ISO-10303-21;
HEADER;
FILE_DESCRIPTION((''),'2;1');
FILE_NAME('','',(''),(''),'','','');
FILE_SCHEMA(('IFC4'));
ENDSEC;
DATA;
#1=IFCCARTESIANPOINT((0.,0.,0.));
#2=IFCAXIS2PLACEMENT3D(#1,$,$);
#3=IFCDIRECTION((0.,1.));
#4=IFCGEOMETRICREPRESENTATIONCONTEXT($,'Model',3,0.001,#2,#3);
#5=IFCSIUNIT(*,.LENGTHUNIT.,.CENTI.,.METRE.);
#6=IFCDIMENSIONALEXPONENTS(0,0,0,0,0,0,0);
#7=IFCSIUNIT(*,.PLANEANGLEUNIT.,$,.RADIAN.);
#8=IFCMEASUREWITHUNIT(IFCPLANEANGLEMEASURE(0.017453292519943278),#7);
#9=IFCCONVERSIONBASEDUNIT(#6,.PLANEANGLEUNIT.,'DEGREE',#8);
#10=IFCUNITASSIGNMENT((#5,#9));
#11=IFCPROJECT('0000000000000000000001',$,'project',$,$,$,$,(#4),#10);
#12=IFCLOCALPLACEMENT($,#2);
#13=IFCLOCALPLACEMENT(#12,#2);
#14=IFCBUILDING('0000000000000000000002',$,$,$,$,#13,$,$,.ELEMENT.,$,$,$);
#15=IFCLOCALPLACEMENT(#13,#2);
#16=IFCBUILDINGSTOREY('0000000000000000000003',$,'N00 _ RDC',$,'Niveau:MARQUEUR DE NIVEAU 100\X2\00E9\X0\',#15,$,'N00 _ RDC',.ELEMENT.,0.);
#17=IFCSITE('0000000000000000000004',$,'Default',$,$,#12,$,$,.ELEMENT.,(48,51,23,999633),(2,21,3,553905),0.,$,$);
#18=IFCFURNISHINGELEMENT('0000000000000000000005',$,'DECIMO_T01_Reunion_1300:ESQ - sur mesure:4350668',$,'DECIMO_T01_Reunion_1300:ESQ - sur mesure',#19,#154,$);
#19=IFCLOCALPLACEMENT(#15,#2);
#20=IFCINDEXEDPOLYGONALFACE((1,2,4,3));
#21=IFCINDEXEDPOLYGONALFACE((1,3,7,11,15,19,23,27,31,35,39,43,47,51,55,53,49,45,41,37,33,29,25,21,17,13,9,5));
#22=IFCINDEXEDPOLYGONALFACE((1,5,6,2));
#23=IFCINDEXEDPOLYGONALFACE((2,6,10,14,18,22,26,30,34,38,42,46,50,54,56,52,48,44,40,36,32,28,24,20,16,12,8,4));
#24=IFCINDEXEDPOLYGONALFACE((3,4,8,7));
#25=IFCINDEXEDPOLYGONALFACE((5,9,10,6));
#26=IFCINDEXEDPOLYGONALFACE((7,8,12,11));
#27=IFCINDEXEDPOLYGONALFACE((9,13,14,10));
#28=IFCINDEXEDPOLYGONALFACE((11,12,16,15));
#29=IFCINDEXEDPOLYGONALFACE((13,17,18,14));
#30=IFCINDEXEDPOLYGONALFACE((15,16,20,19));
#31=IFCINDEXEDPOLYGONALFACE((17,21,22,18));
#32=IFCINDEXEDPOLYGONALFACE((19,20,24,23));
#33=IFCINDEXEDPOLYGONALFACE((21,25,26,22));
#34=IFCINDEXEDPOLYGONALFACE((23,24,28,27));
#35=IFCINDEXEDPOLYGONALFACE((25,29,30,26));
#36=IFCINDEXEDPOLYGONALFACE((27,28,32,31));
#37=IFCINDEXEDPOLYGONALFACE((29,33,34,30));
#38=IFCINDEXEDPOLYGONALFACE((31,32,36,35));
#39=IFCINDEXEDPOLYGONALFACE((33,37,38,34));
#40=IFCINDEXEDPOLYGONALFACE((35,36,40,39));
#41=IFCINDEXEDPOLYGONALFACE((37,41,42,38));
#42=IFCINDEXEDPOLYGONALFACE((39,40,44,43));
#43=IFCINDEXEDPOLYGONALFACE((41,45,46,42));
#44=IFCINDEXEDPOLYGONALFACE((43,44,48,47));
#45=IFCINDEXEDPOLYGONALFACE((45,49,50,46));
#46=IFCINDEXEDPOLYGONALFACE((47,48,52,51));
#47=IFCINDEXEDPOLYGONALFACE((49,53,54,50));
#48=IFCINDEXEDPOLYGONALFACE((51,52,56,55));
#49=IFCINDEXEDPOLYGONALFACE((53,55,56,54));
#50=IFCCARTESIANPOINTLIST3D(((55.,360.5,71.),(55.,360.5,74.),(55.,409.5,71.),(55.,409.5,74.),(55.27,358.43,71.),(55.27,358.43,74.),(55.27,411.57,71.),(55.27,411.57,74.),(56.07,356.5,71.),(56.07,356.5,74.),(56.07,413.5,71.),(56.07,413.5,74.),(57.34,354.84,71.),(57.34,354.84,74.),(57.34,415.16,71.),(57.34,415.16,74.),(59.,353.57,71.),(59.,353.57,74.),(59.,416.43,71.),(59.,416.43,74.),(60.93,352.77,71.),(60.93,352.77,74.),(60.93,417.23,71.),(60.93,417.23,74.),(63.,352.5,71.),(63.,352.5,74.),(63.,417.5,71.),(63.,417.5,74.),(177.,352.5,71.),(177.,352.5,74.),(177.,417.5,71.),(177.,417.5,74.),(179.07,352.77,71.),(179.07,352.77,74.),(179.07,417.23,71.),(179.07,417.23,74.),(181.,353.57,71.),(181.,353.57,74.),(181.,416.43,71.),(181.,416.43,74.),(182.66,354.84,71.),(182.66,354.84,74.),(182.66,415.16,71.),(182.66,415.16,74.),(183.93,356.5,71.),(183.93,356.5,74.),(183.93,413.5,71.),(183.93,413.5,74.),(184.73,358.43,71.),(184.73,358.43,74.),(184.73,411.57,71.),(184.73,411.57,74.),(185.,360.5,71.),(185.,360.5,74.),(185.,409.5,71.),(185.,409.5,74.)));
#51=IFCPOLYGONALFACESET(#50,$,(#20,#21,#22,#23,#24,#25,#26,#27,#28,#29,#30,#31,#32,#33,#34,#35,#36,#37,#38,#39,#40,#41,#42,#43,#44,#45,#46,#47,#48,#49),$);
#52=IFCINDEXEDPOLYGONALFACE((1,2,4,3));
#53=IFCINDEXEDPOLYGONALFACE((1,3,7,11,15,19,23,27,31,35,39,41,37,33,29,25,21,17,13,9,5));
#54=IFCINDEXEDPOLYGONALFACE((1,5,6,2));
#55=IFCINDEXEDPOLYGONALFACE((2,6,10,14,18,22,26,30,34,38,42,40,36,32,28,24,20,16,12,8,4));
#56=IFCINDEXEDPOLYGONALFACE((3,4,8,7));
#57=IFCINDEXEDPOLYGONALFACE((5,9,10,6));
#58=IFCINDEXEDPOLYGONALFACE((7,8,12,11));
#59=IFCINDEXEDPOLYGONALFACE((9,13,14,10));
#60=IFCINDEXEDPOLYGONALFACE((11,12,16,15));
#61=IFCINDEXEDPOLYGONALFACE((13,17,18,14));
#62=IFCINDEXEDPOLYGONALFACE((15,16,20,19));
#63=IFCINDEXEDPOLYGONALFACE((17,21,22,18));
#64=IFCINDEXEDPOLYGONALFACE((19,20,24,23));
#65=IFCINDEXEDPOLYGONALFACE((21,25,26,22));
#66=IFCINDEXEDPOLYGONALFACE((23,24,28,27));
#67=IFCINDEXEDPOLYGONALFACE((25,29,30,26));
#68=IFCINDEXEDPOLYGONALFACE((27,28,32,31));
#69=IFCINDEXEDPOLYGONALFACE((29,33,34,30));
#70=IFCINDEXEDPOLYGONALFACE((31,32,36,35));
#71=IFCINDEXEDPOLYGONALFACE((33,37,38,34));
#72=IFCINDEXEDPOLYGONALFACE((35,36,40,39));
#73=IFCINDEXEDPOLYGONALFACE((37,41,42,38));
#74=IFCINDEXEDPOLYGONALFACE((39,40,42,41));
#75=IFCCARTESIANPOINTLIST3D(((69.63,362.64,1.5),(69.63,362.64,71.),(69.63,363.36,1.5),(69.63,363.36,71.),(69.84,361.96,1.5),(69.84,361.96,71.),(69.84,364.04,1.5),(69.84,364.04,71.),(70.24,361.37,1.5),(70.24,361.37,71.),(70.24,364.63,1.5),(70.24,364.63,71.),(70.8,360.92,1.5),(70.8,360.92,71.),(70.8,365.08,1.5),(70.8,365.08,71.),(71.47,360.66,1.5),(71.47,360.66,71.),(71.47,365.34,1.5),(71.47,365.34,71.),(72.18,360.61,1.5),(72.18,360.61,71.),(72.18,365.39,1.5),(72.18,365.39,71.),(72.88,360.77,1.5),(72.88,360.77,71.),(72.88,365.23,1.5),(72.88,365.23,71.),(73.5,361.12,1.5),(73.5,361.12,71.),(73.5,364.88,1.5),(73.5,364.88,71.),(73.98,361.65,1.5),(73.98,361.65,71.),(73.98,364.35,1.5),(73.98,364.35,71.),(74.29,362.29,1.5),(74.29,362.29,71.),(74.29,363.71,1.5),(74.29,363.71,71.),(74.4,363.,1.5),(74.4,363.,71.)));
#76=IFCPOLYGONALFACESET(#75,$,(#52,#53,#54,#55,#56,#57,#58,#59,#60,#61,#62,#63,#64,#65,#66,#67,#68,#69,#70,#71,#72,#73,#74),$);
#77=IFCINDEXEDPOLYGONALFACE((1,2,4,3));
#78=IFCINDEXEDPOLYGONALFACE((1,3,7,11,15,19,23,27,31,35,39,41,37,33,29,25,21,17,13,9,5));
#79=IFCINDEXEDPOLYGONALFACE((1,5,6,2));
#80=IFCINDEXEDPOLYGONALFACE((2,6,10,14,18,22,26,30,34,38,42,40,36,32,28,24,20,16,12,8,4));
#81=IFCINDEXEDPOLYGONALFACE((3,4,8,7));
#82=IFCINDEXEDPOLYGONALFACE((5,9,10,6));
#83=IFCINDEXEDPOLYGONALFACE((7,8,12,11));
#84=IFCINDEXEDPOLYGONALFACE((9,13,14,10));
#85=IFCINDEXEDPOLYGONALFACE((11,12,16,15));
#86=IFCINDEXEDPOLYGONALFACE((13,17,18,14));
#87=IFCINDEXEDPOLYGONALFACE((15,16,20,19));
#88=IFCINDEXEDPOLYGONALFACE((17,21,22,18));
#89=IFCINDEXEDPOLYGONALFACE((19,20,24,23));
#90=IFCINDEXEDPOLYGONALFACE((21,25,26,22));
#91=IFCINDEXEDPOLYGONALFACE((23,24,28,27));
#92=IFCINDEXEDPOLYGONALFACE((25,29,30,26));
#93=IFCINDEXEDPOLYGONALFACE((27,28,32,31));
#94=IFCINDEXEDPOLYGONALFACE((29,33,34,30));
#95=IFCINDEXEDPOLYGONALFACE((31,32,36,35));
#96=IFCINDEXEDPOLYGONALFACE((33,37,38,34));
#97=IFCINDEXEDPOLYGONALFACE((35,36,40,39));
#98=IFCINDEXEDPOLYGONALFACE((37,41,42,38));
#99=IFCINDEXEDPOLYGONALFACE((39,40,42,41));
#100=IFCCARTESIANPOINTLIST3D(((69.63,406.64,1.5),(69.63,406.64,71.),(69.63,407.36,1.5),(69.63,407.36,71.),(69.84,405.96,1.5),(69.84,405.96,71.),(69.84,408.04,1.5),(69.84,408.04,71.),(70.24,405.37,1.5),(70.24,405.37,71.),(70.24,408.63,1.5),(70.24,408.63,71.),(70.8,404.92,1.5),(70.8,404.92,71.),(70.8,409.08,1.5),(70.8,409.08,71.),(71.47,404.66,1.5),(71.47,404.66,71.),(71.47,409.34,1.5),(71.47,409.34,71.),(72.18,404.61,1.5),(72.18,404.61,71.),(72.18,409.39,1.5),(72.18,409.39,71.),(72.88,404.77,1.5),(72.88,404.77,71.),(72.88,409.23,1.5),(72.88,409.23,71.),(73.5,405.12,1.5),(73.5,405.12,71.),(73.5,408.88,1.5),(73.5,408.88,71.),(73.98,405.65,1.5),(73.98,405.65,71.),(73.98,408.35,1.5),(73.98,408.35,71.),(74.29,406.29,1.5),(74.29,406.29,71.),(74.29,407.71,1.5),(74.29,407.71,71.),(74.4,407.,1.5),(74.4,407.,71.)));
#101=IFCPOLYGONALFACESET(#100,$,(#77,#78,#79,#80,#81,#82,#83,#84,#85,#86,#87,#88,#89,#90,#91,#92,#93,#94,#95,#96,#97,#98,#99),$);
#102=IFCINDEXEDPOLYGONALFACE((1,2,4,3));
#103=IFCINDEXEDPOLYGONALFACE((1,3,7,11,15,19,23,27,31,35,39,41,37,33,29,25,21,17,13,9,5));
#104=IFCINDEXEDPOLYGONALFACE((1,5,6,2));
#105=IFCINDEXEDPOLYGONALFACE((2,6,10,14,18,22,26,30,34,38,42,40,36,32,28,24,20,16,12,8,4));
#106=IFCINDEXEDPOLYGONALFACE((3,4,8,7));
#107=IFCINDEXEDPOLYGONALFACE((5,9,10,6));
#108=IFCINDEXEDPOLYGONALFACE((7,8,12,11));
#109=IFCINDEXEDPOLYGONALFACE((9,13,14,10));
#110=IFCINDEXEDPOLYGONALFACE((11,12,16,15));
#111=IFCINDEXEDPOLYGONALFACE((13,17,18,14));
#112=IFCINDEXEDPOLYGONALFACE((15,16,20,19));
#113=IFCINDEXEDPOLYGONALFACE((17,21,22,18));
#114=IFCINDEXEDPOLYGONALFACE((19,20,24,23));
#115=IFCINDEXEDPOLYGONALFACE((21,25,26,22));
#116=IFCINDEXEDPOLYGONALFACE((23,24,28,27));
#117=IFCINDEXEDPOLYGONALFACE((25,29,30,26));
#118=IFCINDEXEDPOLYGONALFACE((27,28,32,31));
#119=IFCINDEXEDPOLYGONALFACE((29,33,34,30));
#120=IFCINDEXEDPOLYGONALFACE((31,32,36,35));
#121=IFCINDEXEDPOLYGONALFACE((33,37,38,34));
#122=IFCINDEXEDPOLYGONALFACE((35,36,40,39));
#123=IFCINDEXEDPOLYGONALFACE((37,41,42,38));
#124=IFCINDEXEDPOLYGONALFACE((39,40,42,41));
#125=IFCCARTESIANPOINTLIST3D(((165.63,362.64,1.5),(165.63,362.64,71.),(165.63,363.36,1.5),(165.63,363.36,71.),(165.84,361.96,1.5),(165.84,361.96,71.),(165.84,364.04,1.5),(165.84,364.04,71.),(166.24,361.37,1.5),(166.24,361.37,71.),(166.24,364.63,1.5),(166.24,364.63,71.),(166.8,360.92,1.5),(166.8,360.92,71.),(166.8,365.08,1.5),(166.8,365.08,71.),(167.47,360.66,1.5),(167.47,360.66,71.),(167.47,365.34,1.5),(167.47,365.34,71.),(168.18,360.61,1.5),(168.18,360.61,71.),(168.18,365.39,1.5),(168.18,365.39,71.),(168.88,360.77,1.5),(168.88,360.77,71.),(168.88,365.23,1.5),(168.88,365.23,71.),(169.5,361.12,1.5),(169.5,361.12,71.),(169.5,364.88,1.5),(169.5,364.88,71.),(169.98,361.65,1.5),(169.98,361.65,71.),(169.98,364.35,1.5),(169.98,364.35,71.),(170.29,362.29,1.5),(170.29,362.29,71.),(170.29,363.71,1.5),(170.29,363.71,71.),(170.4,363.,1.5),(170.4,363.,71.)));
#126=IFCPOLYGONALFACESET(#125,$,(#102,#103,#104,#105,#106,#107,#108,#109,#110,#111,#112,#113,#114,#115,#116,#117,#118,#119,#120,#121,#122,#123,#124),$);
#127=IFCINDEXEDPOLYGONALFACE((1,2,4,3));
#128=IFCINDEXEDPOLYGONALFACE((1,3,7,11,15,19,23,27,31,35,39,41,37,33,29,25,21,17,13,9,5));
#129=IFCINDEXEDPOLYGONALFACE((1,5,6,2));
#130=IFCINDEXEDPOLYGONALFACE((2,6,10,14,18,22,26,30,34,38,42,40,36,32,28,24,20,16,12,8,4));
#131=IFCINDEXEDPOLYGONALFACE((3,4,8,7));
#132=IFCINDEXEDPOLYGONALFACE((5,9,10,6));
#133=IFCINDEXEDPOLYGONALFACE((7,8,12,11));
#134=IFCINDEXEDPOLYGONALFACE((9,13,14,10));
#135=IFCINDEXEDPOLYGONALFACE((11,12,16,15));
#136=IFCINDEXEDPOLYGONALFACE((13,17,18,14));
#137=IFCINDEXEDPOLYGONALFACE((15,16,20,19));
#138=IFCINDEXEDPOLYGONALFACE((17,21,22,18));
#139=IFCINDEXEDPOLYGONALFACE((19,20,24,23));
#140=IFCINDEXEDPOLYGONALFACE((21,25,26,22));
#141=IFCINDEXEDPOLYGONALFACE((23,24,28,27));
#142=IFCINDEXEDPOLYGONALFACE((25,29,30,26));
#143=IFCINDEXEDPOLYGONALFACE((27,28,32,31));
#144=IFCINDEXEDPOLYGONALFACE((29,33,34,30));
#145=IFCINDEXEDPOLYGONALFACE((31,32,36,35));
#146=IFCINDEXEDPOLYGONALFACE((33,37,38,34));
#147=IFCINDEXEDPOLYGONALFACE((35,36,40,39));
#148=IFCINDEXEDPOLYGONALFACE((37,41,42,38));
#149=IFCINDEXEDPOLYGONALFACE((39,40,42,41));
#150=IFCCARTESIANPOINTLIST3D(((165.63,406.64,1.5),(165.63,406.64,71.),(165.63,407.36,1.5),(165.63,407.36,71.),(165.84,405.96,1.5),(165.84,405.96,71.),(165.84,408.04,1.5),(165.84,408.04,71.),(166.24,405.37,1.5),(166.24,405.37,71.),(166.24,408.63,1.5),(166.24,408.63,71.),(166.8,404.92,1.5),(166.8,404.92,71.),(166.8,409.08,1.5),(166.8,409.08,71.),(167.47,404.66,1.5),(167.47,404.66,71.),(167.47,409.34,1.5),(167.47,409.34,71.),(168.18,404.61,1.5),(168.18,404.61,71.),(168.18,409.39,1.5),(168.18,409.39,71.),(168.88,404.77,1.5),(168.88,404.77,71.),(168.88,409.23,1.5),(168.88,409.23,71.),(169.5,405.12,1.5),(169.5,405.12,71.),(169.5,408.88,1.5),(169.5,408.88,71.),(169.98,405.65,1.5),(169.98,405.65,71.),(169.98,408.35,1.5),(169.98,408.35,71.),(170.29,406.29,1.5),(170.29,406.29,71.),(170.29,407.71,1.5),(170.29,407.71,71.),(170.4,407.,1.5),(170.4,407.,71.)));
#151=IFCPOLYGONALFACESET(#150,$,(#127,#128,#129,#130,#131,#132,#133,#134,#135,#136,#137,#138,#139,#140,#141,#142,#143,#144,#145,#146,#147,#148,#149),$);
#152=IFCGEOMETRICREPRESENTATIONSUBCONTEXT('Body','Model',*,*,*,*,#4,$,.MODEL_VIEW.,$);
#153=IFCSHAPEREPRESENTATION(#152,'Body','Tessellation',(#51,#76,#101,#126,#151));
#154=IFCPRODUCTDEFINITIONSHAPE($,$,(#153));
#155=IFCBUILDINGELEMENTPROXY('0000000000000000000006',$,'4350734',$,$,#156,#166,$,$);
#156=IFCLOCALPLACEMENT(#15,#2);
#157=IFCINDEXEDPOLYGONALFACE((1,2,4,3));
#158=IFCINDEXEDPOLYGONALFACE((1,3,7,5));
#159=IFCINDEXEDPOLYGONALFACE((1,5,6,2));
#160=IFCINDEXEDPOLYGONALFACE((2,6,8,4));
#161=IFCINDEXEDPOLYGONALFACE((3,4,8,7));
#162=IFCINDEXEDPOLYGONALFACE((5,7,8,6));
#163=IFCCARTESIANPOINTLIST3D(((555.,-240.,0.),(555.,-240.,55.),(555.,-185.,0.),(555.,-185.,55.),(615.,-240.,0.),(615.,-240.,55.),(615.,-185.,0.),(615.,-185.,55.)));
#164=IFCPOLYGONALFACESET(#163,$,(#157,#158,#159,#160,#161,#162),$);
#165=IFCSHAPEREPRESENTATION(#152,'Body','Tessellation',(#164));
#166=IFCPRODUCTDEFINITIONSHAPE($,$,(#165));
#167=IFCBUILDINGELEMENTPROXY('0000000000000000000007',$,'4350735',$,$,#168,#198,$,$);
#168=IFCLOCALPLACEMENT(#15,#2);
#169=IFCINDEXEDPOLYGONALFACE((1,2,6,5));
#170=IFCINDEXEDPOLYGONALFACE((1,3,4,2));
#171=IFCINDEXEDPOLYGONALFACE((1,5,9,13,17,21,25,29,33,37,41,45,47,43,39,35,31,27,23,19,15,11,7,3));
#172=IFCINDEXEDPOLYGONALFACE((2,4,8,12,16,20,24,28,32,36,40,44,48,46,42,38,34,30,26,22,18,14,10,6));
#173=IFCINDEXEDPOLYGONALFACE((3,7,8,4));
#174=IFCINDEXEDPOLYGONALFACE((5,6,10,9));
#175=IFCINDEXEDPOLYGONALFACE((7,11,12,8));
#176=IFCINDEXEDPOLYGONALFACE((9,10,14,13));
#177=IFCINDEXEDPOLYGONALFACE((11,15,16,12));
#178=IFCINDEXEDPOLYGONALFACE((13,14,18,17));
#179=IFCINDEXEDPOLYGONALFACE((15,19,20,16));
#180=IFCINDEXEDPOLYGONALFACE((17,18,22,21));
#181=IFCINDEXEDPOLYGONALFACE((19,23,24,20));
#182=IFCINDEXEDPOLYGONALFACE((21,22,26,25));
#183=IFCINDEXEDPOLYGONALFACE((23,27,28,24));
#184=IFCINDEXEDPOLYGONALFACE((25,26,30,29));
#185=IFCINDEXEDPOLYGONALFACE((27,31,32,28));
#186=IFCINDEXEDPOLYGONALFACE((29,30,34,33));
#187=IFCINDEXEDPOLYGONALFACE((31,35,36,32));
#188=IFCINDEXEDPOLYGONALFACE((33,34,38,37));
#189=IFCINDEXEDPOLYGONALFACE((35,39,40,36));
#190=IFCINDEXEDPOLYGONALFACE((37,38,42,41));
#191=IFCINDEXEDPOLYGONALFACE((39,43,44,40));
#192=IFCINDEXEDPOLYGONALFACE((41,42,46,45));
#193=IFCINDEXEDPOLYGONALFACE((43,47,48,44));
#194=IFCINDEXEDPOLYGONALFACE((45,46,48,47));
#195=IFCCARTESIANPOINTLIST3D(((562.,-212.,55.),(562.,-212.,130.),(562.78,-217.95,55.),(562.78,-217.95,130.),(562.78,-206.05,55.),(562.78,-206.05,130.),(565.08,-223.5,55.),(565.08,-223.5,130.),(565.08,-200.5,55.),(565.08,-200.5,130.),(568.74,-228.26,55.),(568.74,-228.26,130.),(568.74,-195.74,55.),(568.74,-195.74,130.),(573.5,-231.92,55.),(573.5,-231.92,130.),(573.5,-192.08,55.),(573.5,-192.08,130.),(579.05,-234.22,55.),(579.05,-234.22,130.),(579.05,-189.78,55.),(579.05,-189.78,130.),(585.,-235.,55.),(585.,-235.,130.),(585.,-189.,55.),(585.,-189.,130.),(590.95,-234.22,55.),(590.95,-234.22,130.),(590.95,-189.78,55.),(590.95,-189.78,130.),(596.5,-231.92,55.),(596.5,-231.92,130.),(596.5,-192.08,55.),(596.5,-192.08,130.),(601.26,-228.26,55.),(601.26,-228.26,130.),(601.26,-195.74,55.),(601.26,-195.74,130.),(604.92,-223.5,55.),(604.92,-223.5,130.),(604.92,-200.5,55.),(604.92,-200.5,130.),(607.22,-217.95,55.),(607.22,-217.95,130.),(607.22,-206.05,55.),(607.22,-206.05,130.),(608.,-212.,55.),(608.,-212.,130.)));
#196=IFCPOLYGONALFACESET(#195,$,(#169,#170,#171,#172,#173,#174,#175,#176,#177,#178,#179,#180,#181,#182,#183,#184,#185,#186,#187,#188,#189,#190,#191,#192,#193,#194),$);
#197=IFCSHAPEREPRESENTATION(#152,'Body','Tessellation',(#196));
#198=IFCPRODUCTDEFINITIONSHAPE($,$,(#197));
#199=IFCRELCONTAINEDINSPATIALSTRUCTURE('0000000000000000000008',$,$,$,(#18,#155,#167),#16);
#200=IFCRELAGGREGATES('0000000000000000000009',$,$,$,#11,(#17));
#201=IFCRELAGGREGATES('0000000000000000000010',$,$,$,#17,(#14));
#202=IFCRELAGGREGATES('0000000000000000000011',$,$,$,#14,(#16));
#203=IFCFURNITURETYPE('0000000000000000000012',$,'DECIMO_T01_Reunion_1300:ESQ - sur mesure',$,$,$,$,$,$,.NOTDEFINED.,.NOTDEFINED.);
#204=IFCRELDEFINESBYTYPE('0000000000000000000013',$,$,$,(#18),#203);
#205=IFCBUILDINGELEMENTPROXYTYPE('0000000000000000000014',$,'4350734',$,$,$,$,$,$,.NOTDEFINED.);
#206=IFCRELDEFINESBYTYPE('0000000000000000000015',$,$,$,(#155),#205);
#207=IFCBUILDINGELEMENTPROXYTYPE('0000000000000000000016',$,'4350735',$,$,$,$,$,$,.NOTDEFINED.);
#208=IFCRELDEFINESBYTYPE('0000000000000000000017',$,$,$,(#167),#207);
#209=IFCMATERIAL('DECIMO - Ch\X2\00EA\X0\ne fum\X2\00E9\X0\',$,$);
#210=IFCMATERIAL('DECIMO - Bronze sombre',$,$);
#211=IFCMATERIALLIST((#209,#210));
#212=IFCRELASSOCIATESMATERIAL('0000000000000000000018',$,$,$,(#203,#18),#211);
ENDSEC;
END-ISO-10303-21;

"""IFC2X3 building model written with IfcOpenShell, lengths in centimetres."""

from ifc_helpers import new_model, entity, si_unit, converted_unit, direction, frame, frame_2d, origin, origin_2d_with_axis, place, context, subcontext, project, spatial, polyline, circle_curve, parameter, trimmed, segment, composite_curve, rectangle, circle, outline, extrude, source, transform, mapped, material, material_list, type_object, type_shapes, element, save


model = new_model("IFC2X3")

# Units and contexts
model_context = context("Model", 3, precision=0.001, world=origin(), true_north=direction((0.0, 1.0)))
body_context = subcontext(model_context, "Body", "Model", "MODEL_VIEW")
ifc_project = project(units=[si_unit("LENGTHUNIT", "METRE", prefix="CENTI"), converted_unit("PLANEANGLEUNIT", "DEGREE", entity("IfcPlaneAngleMeasure", 0.017453292519943278), si_unit("PLANEANGLEUNIT", "RADIAN"), dimensions=[0, 0, 0, 0, 0, 0, 0])], contexts=[model_context])

# Site, building, storey
site_placement = place(None, origin())
site = spatial("IfcSite", under=ifc_project, at=site_placement, Name="Default", CompositionType="ELEMENT", RefLatitude=(48, 51, 23, 999633), RefLongitude=(2, 21, 3, 553905), RefElevation=0.0)
building_placement = place(site_placement, origin())
building = spatial("IfcBuilding", under=site, at=building_placement, CompositionType="ELEMENT")
storey_placement = place(building_placement, origin())
storey = spatial("IfcBuildingStorey", under=building, at=storey_placement, Name="N00 _ RDC", ObjectType="Niveau:MARQUEUR DE NIVEAU 100é", LongName="N00 _ RDC", CompositionType="ELEMENT", Elevation=0.0)

# Furnishing element
ifc_material_1 = material(Name="DECIMO - Bronze sombre")
ifc_material_2 = material(Name="DECIMO - Chêne fumé")
ifc_material_list_1 = material_list([ifc_material_2, ifc_material_1])
furniture_type_1 = type_object("IfcFurnitureType", Name="DECIMO_T01_Reunion_1300:ESQ - sur mesure", AssemblyPlace="NOTDEFINED", material=ifc_material_list_1)
shared_shape_1 = source(origin(), body_context, "Body", "SweptSolid", [
    extrude(outline(composite_curve([segment(polyline([(-57.0, -32.5), (57.0, -32.5)]), True, "CONTINUOUS"), segment(trimmed(circle_curve(frame_2d((57.0, -24.5), x_axis=(1.0, 0.0)), 8.0), [parameter(270.0)], [parameter(0.0)], True, "PARAMETER"), True, "CONTINUOUS"), segment(polyline([(65.0, -24.5), (65.0, 24.5)]), True, "CONTINUOUS"), segment(trimmed(circle_curve(frame_2d((57.0, 24.5), x_axis=(1.0, 0.0)), 8.0), [parameter(0.0)], [parameter(90.0)], True, "PARAMETER"), True, "CONTINUOUS"), segment(polyline([(57.0, 32.5), (-57.0, 32.5)]), True, "CONTINUOUS"), segment(trimmed(circle_curve(frame_2d((-57.0, 24.5), x_axis=(1.0, 0.0)), 8.0), [parameter(90.0)], [parameter(180.0)], True, "PARAMETER"), True, "CONTINUOUS"), segment(polyline([(-65.0, 24.5), (-65.0, -24.5)]), True, "CONTINUOUS"), segment(trimmed(circle_curve(frame_2d((-57.0, -24.5), x_axis=(1.0, 0.0)), 8.0), [parameter(180.0)], [parameter(270.0)], True, "PARAMETER"), True, "CONTINUOUS")], self_intersect=False)), frame((0.0, 0.0, 71.0)), (0.0, 0.0, 1.0), 3.0),
    extrude(circle(Radius=2.4, at=origin_2d_with_axis()), frame((-48.0, -22.0, 1.5)), (0.0, 0.0, 1.0), 69.5),
    extrude(circle(Radius=2.4, at=origin_2d_with_axis()), frame((-48.0, 22.0, 1.5)), (0.0, 0.0, 1.0), 69.5),
    extrude(circle(Radius=2.4, at=origin_2d_with_axis()), frame((48.0, -22.0, 1.5)), (0.0, 0.0, 1.0), 69.5),
    extrude(circle(Radius=2.4, at=origin_2d_with_axis()), frame((48.0, 22.0, 1.5)), (0.0, 0.0, 1.0), 69.5),
])
type_shapes(furniture_type_1, [shared_shape_1])
furnishing_1_placement = place(storey_placement, frame((120.0, 385.0, 0.0)))
element("IfcFurnishingElement", 1, at=furnishing_1_placement, inside=storey, type_object=furniture_type_1, material=ifc_material_list_1, Name="DECIMO_T01_Reunion_1300:ESQ - sur mesure:4350668", ObjectType="DECIMO_T01_Reunion_1300:ESQ - sur mesure", context=body_context, shape_type="MappedRepresentation", body=[
    mapped(shared_shape_1, transform((0.0, 0.0, 0.0), scale=1.0)),
])

# Building element proxies
building_element_proxy_type_1 = type_object("IfcBuildingElementProxyType", Name="4350734", PredefinedType="NOTDEFINED")
proxy_1_placement = place(storey_placement, origin())
element("IfcBuildingElementProxy", 2, at=proxy_1_placement, inside=storey, type_object=building_element_proxy_type_1, Name="4350734", context=body_context, shape_type="SweptSolid", body=[
    extrude(rectangle(XDim=60.0, YDim=55.0, at=origin_2d_with_axis()), frame((585.0, -212.5, 0.0)), (0.0, 0.0, 1.0), 55.0),
])
building_element_proxy_type_2 = type_object("IfcBuildingElementProxyType", Name="4350735", PredefinedType="NOTDEFINED")
proxy_2_placement = place(storey_placement, origin())
element("IfcBuildingElementProxy", 3, at=proxy_2_placement, inside=storey, type_object=building_element_proxy_type_2, Name="4350735", context=body_context, shape_type="SweptSolid", body=[
    extrude(circle(Radius=23.0, at=origin_2d_with_axis()), frame((585.0, -212.0, 55.0)), (0.0, 0.0, 1.0), 75.0),
])

save(model, "model.ifc")
